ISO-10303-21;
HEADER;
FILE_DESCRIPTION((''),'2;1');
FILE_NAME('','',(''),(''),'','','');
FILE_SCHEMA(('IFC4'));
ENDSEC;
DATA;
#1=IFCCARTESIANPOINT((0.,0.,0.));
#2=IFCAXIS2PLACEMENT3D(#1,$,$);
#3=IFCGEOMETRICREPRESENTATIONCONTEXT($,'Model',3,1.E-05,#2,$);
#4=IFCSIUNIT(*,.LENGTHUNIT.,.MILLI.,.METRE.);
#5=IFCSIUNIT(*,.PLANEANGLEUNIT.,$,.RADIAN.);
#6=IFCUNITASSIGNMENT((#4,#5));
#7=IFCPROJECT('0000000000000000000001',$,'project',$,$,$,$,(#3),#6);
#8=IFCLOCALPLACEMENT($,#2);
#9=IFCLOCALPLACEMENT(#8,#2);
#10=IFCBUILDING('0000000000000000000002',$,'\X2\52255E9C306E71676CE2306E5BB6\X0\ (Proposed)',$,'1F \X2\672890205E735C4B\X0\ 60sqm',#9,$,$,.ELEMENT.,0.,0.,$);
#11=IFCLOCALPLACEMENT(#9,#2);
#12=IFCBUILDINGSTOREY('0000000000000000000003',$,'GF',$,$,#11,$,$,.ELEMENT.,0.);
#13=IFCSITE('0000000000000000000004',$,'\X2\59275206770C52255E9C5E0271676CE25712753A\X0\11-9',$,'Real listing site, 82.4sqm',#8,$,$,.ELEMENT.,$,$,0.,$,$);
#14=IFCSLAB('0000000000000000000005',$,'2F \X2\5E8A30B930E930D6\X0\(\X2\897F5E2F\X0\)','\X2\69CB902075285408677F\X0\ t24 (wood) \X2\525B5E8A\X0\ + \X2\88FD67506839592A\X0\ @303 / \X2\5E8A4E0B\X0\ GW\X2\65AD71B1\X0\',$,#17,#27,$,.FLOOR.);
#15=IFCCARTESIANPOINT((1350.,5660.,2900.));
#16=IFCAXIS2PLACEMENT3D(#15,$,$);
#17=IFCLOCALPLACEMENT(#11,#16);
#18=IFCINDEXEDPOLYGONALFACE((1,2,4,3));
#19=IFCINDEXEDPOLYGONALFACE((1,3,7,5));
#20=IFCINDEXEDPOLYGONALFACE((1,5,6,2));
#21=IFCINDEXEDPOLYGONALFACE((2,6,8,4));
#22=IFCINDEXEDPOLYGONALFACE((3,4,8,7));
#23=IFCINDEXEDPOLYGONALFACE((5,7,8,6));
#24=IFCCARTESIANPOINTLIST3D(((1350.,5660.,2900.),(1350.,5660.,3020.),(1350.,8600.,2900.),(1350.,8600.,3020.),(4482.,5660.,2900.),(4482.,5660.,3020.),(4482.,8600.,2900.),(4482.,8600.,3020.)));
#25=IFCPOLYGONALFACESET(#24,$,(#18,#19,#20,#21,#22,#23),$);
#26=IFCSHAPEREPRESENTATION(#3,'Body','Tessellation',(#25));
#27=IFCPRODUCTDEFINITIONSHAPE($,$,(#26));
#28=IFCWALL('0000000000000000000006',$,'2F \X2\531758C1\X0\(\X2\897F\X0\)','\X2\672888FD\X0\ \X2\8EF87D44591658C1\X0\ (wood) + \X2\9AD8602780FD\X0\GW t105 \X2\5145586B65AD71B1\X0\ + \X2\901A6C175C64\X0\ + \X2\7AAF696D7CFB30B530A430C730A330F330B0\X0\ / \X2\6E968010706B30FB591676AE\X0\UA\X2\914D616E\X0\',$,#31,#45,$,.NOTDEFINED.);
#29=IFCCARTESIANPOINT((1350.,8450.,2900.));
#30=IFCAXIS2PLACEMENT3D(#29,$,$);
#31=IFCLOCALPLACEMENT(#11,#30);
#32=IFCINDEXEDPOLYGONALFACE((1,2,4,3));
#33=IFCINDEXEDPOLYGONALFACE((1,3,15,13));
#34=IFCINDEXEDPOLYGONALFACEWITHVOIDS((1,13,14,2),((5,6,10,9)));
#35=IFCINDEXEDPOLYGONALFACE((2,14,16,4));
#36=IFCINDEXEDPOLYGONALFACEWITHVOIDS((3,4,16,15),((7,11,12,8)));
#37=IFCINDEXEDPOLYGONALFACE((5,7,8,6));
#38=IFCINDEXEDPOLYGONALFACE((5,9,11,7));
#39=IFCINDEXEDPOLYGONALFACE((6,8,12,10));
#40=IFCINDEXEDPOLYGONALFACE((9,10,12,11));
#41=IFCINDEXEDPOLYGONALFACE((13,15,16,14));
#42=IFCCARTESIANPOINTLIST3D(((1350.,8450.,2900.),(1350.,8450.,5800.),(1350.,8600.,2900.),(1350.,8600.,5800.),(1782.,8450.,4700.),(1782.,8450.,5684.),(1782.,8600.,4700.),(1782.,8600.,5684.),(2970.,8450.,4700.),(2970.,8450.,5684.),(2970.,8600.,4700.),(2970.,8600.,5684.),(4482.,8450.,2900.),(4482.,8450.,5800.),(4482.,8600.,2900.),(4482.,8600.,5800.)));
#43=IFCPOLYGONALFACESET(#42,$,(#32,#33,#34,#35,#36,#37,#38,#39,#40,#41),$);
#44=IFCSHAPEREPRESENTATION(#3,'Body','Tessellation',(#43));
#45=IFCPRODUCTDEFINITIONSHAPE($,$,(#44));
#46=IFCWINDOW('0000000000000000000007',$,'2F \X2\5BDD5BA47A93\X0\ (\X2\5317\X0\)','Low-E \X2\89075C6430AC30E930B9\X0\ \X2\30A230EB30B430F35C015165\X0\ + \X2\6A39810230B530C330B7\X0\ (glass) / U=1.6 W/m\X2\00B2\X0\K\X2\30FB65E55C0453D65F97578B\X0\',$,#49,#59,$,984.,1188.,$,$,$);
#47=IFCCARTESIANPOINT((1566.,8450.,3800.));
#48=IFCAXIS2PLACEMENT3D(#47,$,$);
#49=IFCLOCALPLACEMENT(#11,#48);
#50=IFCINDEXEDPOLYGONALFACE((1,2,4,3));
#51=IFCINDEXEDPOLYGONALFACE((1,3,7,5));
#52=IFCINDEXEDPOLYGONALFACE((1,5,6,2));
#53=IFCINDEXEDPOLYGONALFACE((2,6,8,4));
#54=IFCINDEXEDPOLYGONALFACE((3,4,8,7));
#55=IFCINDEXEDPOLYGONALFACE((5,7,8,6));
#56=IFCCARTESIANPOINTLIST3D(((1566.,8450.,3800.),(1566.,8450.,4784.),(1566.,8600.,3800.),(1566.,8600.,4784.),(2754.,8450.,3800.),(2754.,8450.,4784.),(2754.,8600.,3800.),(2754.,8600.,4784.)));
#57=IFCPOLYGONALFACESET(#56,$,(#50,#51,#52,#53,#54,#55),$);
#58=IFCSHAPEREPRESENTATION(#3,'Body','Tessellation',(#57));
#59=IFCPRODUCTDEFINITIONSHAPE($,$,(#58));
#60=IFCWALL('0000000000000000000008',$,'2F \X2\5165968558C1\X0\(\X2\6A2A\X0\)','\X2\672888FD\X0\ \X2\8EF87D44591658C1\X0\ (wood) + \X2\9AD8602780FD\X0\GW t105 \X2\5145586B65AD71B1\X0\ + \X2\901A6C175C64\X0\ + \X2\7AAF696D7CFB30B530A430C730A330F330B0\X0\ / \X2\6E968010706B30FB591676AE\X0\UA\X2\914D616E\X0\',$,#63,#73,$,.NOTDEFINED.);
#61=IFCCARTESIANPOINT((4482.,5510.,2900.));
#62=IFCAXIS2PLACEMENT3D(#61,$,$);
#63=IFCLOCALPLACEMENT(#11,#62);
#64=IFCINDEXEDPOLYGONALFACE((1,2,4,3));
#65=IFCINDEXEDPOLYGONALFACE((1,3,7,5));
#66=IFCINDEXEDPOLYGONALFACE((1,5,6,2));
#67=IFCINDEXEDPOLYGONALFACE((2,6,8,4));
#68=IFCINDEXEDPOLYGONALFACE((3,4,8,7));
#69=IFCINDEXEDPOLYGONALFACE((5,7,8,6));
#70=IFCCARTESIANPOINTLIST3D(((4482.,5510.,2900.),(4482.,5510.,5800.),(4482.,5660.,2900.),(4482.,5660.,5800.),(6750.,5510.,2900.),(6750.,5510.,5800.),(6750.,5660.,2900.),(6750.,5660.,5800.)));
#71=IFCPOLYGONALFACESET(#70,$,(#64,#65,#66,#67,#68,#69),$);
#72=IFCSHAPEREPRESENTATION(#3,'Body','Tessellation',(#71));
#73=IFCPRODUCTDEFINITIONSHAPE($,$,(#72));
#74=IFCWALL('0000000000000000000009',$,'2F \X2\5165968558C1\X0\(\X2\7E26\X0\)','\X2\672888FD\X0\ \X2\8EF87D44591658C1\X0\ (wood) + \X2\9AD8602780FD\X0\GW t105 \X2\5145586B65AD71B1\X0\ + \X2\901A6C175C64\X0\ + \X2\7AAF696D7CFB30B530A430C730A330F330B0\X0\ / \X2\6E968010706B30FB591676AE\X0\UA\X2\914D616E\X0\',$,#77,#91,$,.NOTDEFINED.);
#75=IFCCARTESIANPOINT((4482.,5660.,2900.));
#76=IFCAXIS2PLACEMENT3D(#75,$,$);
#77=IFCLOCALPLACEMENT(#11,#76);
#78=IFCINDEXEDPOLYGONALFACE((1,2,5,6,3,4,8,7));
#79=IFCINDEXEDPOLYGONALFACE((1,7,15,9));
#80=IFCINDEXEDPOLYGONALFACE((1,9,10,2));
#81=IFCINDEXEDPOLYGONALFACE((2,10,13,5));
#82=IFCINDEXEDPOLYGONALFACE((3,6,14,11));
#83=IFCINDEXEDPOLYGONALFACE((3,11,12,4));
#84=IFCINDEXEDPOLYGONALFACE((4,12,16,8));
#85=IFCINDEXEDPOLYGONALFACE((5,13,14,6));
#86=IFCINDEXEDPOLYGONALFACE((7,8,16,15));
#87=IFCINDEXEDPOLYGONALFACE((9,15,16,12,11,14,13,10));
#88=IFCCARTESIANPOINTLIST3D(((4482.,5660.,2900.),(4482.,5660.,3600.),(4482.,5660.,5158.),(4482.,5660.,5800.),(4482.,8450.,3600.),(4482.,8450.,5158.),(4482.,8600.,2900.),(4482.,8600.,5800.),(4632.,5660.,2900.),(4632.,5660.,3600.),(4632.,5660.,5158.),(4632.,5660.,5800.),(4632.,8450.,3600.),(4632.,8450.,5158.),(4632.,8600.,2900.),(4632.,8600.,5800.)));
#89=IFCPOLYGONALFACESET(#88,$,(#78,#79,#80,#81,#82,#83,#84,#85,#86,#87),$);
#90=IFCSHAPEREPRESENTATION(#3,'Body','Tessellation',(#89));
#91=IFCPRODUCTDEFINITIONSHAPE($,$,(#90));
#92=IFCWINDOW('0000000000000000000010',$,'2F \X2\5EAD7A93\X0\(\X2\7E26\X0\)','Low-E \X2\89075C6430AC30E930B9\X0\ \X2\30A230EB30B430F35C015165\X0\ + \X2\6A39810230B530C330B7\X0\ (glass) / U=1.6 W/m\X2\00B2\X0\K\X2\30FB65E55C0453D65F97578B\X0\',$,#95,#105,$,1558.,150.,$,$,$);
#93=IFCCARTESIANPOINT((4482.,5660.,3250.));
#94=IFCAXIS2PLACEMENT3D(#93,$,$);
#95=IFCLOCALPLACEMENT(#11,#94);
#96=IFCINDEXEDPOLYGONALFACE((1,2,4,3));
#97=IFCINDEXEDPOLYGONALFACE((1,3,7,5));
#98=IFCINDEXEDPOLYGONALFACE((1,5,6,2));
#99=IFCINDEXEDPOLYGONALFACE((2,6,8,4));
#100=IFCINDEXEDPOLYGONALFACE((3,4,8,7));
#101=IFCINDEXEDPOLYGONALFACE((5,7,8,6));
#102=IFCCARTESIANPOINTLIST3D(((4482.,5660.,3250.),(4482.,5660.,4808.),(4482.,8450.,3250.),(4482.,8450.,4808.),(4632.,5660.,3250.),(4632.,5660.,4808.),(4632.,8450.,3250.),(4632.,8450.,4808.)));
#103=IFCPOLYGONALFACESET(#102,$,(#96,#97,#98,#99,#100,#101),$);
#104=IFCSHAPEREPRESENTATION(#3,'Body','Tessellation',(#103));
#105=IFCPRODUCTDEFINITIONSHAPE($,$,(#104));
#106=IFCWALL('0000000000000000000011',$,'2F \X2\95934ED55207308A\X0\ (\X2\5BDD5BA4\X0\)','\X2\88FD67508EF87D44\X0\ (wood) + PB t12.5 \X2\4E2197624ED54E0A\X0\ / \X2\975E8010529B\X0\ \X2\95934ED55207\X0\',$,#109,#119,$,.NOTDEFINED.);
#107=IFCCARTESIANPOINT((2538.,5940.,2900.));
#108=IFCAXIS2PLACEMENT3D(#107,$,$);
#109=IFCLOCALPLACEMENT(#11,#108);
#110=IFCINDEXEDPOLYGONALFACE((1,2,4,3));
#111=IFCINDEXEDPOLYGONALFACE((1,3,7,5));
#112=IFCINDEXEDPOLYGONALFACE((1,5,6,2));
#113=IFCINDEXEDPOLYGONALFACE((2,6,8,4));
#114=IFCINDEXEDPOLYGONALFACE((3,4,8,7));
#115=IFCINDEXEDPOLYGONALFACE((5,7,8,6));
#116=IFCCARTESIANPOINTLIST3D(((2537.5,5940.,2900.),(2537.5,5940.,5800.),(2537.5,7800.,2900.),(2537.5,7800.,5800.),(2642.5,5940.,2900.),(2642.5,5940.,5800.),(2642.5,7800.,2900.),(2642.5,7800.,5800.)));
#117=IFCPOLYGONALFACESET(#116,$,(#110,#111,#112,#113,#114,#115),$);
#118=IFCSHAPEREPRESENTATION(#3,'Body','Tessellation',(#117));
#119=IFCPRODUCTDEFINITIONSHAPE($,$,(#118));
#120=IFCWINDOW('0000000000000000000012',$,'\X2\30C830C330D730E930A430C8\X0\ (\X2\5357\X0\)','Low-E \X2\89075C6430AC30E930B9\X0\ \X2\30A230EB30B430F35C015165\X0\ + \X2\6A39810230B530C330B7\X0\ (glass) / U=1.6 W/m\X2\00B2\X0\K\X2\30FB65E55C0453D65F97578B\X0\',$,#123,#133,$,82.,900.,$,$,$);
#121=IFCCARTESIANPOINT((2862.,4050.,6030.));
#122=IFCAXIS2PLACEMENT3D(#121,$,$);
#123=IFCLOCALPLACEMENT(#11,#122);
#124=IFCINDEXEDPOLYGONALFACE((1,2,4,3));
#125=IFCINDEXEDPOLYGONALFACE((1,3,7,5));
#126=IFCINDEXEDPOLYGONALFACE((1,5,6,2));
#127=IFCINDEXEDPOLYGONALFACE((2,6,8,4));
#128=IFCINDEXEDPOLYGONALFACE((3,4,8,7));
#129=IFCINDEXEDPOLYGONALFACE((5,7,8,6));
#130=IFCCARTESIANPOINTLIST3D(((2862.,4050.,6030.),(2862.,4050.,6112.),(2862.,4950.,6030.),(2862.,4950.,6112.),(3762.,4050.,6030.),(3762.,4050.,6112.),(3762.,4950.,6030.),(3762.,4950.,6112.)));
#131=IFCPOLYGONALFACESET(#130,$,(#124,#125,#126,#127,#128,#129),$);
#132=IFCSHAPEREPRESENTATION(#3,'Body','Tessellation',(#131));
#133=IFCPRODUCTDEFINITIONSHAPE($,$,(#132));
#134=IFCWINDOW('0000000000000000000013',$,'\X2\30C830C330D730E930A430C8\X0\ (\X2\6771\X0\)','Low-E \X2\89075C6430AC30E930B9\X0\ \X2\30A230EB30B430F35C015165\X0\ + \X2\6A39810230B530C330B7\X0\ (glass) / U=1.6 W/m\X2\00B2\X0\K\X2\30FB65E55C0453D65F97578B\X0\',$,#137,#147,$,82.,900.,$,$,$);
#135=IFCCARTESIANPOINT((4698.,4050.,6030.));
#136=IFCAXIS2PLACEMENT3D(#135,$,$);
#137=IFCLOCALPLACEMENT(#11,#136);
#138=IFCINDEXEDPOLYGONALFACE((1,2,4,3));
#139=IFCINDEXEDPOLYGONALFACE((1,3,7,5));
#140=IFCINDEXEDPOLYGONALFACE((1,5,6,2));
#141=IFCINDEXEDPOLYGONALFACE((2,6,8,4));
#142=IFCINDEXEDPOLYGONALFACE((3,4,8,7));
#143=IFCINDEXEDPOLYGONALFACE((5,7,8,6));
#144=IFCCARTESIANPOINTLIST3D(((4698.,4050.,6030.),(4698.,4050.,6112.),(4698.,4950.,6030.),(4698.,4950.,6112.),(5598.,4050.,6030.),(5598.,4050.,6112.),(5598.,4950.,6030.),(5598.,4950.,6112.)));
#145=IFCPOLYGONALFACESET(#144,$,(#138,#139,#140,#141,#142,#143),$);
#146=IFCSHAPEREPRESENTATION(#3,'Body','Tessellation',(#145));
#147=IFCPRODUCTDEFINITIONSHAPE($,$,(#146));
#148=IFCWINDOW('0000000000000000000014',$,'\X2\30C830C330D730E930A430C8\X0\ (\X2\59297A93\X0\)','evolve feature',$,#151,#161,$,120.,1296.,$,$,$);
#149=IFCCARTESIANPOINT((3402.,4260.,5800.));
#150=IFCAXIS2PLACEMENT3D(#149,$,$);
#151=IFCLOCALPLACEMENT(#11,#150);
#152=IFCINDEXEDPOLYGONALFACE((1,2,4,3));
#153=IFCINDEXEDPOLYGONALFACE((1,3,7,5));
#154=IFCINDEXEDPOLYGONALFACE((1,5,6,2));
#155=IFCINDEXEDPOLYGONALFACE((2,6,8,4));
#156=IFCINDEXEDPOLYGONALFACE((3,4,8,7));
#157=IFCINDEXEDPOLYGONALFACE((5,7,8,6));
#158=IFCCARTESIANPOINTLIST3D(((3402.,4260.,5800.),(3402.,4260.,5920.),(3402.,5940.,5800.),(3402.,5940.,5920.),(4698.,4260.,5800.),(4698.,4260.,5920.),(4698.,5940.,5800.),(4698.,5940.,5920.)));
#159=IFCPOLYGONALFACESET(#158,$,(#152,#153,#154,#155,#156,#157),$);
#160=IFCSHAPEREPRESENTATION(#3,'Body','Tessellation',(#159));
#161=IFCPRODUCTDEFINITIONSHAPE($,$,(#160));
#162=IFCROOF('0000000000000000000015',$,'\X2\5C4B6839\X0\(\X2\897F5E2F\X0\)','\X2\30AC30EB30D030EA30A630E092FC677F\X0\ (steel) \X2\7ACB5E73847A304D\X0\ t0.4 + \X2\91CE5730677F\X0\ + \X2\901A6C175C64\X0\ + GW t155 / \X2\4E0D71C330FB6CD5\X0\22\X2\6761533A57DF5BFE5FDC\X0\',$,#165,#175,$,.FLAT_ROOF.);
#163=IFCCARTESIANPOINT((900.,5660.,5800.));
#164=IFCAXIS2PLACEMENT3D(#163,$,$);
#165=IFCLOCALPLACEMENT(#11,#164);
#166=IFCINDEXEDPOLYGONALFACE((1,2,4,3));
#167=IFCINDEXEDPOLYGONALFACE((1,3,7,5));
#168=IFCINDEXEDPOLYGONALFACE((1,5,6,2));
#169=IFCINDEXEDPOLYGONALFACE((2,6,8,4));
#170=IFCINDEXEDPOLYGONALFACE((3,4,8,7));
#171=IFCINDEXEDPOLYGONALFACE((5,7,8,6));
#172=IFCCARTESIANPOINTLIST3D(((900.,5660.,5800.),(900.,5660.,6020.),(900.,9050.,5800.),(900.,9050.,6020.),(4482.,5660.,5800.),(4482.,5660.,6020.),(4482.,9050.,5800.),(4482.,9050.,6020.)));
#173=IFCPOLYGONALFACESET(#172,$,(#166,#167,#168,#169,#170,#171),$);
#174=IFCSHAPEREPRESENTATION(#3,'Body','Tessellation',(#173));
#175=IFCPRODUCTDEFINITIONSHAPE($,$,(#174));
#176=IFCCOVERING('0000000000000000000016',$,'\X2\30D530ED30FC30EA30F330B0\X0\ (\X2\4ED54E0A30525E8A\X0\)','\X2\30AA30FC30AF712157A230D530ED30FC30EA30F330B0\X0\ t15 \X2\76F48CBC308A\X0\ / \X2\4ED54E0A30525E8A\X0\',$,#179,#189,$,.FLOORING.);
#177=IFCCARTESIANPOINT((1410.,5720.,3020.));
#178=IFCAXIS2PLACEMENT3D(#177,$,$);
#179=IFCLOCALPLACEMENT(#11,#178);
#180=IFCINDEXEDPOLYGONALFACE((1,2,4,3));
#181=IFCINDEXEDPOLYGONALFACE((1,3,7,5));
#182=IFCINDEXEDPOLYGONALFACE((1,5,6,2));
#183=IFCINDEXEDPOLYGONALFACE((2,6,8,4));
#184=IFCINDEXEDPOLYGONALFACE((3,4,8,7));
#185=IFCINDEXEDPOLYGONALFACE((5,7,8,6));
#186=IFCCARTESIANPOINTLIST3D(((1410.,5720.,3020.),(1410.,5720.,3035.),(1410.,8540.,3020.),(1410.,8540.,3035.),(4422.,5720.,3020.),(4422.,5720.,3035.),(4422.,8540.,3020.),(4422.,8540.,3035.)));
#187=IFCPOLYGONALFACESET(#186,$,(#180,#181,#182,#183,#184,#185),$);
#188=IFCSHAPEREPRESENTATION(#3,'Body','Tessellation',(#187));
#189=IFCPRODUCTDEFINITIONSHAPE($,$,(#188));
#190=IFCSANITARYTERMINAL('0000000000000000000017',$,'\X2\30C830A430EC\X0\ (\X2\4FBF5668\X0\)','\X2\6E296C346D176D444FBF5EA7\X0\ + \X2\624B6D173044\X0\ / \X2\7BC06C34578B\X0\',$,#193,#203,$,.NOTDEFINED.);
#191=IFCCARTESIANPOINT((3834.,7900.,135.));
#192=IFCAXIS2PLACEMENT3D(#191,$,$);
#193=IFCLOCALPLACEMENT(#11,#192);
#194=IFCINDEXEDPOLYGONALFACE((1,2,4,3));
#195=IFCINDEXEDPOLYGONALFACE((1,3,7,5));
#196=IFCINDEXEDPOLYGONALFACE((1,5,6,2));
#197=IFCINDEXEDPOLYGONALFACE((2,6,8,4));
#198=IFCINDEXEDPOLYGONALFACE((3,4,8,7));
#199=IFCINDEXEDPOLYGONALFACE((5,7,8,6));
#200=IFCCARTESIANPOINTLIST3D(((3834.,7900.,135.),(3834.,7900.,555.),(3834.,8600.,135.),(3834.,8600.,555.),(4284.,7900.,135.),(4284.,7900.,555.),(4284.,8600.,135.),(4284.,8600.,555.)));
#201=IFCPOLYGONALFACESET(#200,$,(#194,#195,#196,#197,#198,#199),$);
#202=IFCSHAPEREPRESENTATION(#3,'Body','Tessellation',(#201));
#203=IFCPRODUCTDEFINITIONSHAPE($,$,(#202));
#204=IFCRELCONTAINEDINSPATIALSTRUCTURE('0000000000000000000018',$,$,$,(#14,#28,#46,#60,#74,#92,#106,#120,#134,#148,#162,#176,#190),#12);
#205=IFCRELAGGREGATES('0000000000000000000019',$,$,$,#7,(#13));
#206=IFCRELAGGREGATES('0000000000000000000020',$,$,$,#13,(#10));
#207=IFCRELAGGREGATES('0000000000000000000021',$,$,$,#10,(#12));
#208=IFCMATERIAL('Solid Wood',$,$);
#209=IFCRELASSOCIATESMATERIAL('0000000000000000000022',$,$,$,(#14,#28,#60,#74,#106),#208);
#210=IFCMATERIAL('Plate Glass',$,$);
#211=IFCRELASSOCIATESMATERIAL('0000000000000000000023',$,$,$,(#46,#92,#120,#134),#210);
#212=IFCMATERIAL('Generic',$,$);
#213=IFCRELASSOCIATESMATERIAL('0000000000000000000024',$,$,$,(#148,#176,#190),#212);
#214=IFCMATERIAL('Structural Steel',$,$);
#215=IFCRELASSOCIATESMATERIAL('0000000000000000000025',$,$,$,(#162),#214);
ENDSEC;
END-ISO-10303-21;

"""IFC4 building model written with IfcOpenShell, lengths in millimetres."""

from ifc_helpers import new_model, si_unit, frame, frame_2d, origin, place, context, project, spatial, rectangle, extrude, material, element, fill, save


model = new_model("IFC4")

# Units and contexts
model_context = context("Model", 3, precision=1e-05, world=origin())
ifc_project = project(units=[si_unit("LENGTHUNIT", "METRE", prefix="MILLI"), si_unit("PLANEANGLEUNIT", "RADIAN")], contexts=[model_context])

# Site, building, storey
site_placement = place(None, origin())
site = spatial("IfcSite", under=ifc_project, at=site_placement, Name="大分県別府市照波園町11-9", ObjectType="Real listing site, 82.4sqm", CompositionType="ELEMENT", RefElevation=0.0)
building_placement = place(site_placement, origin())
building = spatial("IfcBuilding", under=site, at=building_placement, Name="別府の照波の家 (Proposed)", ObjectType="1F 木造平屋 60sqm", CompositionType="ELEMENT", ElevationOfRefHeight=0.0, ElevationOfTerrain=0.0)
storey_placement = place(building_placement, origin())
storey = spatial("IfcBuildingStorey", under=building, at=storey_placement, Name="GF", CompositionType="ELEMENT", Elevation=0.0)

# Slab
ifc_material_1 = material(Name="Solid Wood")
slab_placement = place(storey_placement, frame((1350.0, 5660.0, 2900.0)))
element("IfcSlab", 1, at=slab_placement, inside=storey, material=ifc_material_1, Name="2F 床スラブ(西帯)", Description="構造用合板 t24 (wood) 剛床 + 製材根太 @303 / 床下 GW断熱", PredefinedType="FLOOR", context=model_context, shape_type="SweptSolid", body=[
    extrude(rectangle(XDim=3132.0, YDim=2940.0, at=frame_2d((1566.0, 1470.0))), frame((1350.0, 5660.0, 2900.0)), (0.0, 0.0, 1.0), 120.0),
])

# Wall, opening, window
wall_1_placement = place(storey_placement, frame((1350.0, 8450.0, 2900.0)))
wall_1 = element("IfcWall", 2, at=wall_1_placement, inside=storey, material=ifc_material_1, Name="2F 北壁(西)", Description="木製 軸組外壁 (wood) + 高性能GW t105 充填断熱 + 通気層 + 窯業系サイディング / 準耐火・外皮UA配慮", PredefinedType="NOTDEFINED", context=model_context, shape_type="SweptSolid", body=[
    extrude(rectangle(XDim=3132.0, YDim=150.0, at=frame_2d((1566.0, 75.0))), frame((1350.0, 8450.0, 2900.0)), (0.0, 0.0, 1.0), 2900.0),
])
opening_1_placement = place(storey_placement, frame((1566.0, 8450.0, 3800.0)))
opening_1 = element("IfcOpeningElement", 3, at=opening_1_placement, cuts=wall_1, PredefinedType="NOTDEFINED", context=model_context, shape_type="SweptSolid", body=[
    extrude(rectangle(XDim=1188.0, YDim=150.0, at=frame_2d((594.0, 75.0))), frame((1566.0, 8450.0, 3800.0)), (0.0, 0.0, 1.0), 984.0),
])
ifc_material_2 = material(Name="Plate Glass")
window_1_placement = place(storey_placement, frame((1566.0, 8450.0, 3800.0)))
window_1 = element("IfcWindow", 4, at=window_1_placement, inside=storey, material=ifc_material_2, Name="2F 寝室窓 (北)", Description="Low-E 複層ガラス アルゴン封入 + 樹脂サッシ (glass) / U=1.6 W/m²K・日射取得型", OverallHeight=984.0, OverallWidth=1188.0, context=model_context, shape_type="SweptSolid", body=[
    extrude(rectangle(XDim=1188.0, YDim=150.0, at=frame_2d((594.0, 75.0))), frame((1566.0, 8450.0, 3800.0)), (0.0, 0.0, 1.0), 984.0),
])
fill(opening_1, window_1)

# Wall
wall_2_placement = place(storey_placement, frame((4482.0, 5510.0, 2900.0)))
element("IfcWall", 5, at=wall_2_placement, inside=storey, material=ifc_material_1, Name="2F 入隅壁(横)", Description="木製 軸組外壁 (wood) + 高性能GW t105 充填断熱 + 通気層 + 窯業系サイディング / 準耐火・外皮UA配慮", PredefinedType="NOTDEFINED", context=model_context, shape_type="SweptSolid", body=[
    extrude(rectangle(XDim=2268.0, YDim=150.0, at=frame_2d((1134.0, 75.0))), frame((4482.0, 5510.0, 2900.0)), (0.0, 0.0, 1.0), 2900.0),
])

# Wall, opening, window
wall_3_placement = place(storey_placement, frame((4482.0, 5660.0, 2900.0)))
wall_3 = element("IfcWall", 6, at=wall_3_placement, inside=storey, material=ifc_material_1, Name="2F 入隅壁(縦)", Description="木製 軸組外壁 (wood) + 高性能GW t105 充填断熱 + 通気層 + 窯業系サイディング / 準耐火・外皮UA配慮", PredefinedType="NOTDEFINED", context=model_context, shape_type="SweptSolid", body=[
    extrude(rectangle(XDim=150.0, YDim=2940.0, at=frame_2d((75.0, 1470.0))), frame((4482.0, 5660.0, 2900.0)), (0.0, 0.0, 1.0), 2900.0),
])
opening_2_placement = place(storey_placement, frame((4482.0, 5660.0, 3250.0)))
opening_2 = element("IfcOpeningElement", 7, at=opening_2_placement, cuts=wall_3, PredefinedType="NOTDEFINED", context=model_context, shape_type="SweptSolid", body=[
    extrude(rectangle(XDim=150.0, YDim=2790.0, at=frame_2d((75.0, 1395.0))), frame((4482.0, 5660.0, 3250.0)), (0.0, 0.0, 1.0), 1558.0),
])
window_2_placement = place(storey_placement, frame((4482.0, 5660.0, 3250.0)))
window_2 = element("IfcWindow", 8, at=window_2_placement, inside=storey, material=ifc_material_2, Name="2F 庭窓(縦)", Description="Low-E 複層ガラス アルゴン封入 + 樹脂サッシ (glass) / U=1.6 W/m²K・日射取得型", OverallHeight=1558.0, OverallWidth=150.0, context=model_context, shape_type="SweptSolid", body=[
    extrude(rectangle(XDim=150.0, YDim=2790.0, at=frame_2d((75.0, 1395.0))), frame((4482.0, 5660.0, 3250.0)), (0.0, 0.0, 1.0), 1558.0),
])
fill(opening_2, window_2)

# Wall
wall_4_placement = place(storey_placement, frame((2538.0, 5940.0, 2900.0)))
element("IfcWall", 9, at=wall_4_placement, inside=storey, material=ifc_material_1, Name="2F 間仕切り (寝室)", Description="製材軸組 (wood) + PB t12.5 両面仕上 / 非耐力 間仕切", PredefinedType="NOTDEFINED", context=model_context, shape_type="SweptSolid", body=[
    extrude(rectangle(XDim=105.0, YDim=1860.0, at=frame_2d((52.0, 930.0))), frame((2538.0, 5940.0, 2900.0)), (0.0, 0.0, 1.0), 2900.0),
])

# Windows
window_3_placement = place(storey_placement, frame((2862.0, 4050.0, 6030.0)))
element("IfcWindow", 10, at=window_3_placement, inside=storey, material=ifc_material_2, Name="トップライト (南)", Description="Low-E 複層ガラス アルゴン封入 + 樹脂サッシ (glass) / U=1.6 W/m²K・日射取得型", OverallHeight=82.0, OverallWidth=900.0, context=model_context, shape_type="SweptSolid", body=[
    extrude(rectangle(XDim=900.0, YDim=900.0, at=frame_2d((450.0, 450.0))), frame((2862.0, 4050.0, 6030.0)), (0.0, 0.0, 1.0), 82.0),
])
window_4_placement = place(storey_placement, frame((4698.0, 4050.0, 6030.0)))
element("IfcWindow", 11, at=window_4_placement, inside=storey, material=ifc_material_2, Name="トップライト (東)", Description="Low-E 複層ガラス アルゴン封入 + 樹脂サッシ (glass) / U=1.6 W/m²K・日射取得型", OverallHeight=82.0, OverallWidth=900.0, context=model_context, shape_type="SweptSolid", body=[
    extrude(rectangle(XDim=900.0, YDim=900.0, at=frame_2d((450.0, 450.0))), frame((4698.0, 4050.0, 6030.0)), (0.0, 0.0, 1.0), 82.0),
])
ifc_material_3 = material(Name="Generic")
window_5_placement = place(storey_placement, frame((3402.0, 4260.0, 5800.0)))
element("IfcWindow", 12, at=window_5_placement, inside=storey, material=ifc_material_3, Name="トップライト (天窓)", Description="evolve feature", OverallHeight=120.0, OverallWidth=1296.0, context=model_context, shape_type="SweptSolid", body=[
    extrude(rectangle(XDim=1296.0, YDim=1680.0, at=frame_2d((648.0, 840.0))), frame((3402.0, 4260.0, 5800.0)), (0.0, 0.0, 1.0), 120.0),
])

# Roof
ifc_material_4 = material(Name="Structural Steel")
for number, where, name in (
    (13, (900.0, 5660.0, 5800.0), "屋根(西帯)"),
):
    element("IfcRoof", number, at=place(storey_placement, frame(where)), inside=storey, material=ifc_material_4, Name=name, Description="ガルバリウム鋼板 (steel) 立平葺き t0.4 + 野地板 + 通気層 + GW t155 / 不燃・法22条区域対応", PredefinedType="FLAT_ROOF", context=model_context, shape_type="SweptSolid", body=[
        extrude(rectangle(XDim=3582.0, YDim=3390.0, at=frame_2d((1791.0, 1695.0))), frame((900.0, 5660.0, 5800.0)), (0.0, 0.0, 1.0), 220.0),
    ])

# Covering
covering_placement = place(storey_placement, frame((1410.0, 5720.0, 3020.0)))
element("IfcCovering", 14, at=covering_placement, inside=storey, material=ifc_material_3, Name="フローリング (仕上げ床)", Description="オーク無垢フローリング t15 直貼り / 仕上げ床", PredefinedType="FLOORING", context=model_context, shape_type="SweptSolid", body=[
    extrude(rectangle(XDim=3012.0, YDim=2820.0, at=frame_2d((1506.0, 1410.0))), frame((1410.0, 5720.0, 3020.0)), (0.0, 0.0, 1.0), 15.0),
])

# Sanitary terminal
sanitary_terminal_placement = place(storey_placement, frame((3834.0, 7900.0, 135.0)))
element("IfcSanitaryTerminal", 15, at=sanitary_terminal_placement, inside=storey, material=ifc_material_3, Name="トイレ (便器)", Description="温水洗浄便座 + 手洗い / 節水型", PredefinedType="NOTDEFINED", context=model_context, shape_type="SweptSolid", body=[
    extrude(rectangle(XDim=450.0, YDim=700.0, at=frame_2d((225.0, 350.0))), frame((3834.0, 7900.0, 135.0)), (0.0, 0.0, 1.0), 420.0),
])

save(model, "model.ifc")
